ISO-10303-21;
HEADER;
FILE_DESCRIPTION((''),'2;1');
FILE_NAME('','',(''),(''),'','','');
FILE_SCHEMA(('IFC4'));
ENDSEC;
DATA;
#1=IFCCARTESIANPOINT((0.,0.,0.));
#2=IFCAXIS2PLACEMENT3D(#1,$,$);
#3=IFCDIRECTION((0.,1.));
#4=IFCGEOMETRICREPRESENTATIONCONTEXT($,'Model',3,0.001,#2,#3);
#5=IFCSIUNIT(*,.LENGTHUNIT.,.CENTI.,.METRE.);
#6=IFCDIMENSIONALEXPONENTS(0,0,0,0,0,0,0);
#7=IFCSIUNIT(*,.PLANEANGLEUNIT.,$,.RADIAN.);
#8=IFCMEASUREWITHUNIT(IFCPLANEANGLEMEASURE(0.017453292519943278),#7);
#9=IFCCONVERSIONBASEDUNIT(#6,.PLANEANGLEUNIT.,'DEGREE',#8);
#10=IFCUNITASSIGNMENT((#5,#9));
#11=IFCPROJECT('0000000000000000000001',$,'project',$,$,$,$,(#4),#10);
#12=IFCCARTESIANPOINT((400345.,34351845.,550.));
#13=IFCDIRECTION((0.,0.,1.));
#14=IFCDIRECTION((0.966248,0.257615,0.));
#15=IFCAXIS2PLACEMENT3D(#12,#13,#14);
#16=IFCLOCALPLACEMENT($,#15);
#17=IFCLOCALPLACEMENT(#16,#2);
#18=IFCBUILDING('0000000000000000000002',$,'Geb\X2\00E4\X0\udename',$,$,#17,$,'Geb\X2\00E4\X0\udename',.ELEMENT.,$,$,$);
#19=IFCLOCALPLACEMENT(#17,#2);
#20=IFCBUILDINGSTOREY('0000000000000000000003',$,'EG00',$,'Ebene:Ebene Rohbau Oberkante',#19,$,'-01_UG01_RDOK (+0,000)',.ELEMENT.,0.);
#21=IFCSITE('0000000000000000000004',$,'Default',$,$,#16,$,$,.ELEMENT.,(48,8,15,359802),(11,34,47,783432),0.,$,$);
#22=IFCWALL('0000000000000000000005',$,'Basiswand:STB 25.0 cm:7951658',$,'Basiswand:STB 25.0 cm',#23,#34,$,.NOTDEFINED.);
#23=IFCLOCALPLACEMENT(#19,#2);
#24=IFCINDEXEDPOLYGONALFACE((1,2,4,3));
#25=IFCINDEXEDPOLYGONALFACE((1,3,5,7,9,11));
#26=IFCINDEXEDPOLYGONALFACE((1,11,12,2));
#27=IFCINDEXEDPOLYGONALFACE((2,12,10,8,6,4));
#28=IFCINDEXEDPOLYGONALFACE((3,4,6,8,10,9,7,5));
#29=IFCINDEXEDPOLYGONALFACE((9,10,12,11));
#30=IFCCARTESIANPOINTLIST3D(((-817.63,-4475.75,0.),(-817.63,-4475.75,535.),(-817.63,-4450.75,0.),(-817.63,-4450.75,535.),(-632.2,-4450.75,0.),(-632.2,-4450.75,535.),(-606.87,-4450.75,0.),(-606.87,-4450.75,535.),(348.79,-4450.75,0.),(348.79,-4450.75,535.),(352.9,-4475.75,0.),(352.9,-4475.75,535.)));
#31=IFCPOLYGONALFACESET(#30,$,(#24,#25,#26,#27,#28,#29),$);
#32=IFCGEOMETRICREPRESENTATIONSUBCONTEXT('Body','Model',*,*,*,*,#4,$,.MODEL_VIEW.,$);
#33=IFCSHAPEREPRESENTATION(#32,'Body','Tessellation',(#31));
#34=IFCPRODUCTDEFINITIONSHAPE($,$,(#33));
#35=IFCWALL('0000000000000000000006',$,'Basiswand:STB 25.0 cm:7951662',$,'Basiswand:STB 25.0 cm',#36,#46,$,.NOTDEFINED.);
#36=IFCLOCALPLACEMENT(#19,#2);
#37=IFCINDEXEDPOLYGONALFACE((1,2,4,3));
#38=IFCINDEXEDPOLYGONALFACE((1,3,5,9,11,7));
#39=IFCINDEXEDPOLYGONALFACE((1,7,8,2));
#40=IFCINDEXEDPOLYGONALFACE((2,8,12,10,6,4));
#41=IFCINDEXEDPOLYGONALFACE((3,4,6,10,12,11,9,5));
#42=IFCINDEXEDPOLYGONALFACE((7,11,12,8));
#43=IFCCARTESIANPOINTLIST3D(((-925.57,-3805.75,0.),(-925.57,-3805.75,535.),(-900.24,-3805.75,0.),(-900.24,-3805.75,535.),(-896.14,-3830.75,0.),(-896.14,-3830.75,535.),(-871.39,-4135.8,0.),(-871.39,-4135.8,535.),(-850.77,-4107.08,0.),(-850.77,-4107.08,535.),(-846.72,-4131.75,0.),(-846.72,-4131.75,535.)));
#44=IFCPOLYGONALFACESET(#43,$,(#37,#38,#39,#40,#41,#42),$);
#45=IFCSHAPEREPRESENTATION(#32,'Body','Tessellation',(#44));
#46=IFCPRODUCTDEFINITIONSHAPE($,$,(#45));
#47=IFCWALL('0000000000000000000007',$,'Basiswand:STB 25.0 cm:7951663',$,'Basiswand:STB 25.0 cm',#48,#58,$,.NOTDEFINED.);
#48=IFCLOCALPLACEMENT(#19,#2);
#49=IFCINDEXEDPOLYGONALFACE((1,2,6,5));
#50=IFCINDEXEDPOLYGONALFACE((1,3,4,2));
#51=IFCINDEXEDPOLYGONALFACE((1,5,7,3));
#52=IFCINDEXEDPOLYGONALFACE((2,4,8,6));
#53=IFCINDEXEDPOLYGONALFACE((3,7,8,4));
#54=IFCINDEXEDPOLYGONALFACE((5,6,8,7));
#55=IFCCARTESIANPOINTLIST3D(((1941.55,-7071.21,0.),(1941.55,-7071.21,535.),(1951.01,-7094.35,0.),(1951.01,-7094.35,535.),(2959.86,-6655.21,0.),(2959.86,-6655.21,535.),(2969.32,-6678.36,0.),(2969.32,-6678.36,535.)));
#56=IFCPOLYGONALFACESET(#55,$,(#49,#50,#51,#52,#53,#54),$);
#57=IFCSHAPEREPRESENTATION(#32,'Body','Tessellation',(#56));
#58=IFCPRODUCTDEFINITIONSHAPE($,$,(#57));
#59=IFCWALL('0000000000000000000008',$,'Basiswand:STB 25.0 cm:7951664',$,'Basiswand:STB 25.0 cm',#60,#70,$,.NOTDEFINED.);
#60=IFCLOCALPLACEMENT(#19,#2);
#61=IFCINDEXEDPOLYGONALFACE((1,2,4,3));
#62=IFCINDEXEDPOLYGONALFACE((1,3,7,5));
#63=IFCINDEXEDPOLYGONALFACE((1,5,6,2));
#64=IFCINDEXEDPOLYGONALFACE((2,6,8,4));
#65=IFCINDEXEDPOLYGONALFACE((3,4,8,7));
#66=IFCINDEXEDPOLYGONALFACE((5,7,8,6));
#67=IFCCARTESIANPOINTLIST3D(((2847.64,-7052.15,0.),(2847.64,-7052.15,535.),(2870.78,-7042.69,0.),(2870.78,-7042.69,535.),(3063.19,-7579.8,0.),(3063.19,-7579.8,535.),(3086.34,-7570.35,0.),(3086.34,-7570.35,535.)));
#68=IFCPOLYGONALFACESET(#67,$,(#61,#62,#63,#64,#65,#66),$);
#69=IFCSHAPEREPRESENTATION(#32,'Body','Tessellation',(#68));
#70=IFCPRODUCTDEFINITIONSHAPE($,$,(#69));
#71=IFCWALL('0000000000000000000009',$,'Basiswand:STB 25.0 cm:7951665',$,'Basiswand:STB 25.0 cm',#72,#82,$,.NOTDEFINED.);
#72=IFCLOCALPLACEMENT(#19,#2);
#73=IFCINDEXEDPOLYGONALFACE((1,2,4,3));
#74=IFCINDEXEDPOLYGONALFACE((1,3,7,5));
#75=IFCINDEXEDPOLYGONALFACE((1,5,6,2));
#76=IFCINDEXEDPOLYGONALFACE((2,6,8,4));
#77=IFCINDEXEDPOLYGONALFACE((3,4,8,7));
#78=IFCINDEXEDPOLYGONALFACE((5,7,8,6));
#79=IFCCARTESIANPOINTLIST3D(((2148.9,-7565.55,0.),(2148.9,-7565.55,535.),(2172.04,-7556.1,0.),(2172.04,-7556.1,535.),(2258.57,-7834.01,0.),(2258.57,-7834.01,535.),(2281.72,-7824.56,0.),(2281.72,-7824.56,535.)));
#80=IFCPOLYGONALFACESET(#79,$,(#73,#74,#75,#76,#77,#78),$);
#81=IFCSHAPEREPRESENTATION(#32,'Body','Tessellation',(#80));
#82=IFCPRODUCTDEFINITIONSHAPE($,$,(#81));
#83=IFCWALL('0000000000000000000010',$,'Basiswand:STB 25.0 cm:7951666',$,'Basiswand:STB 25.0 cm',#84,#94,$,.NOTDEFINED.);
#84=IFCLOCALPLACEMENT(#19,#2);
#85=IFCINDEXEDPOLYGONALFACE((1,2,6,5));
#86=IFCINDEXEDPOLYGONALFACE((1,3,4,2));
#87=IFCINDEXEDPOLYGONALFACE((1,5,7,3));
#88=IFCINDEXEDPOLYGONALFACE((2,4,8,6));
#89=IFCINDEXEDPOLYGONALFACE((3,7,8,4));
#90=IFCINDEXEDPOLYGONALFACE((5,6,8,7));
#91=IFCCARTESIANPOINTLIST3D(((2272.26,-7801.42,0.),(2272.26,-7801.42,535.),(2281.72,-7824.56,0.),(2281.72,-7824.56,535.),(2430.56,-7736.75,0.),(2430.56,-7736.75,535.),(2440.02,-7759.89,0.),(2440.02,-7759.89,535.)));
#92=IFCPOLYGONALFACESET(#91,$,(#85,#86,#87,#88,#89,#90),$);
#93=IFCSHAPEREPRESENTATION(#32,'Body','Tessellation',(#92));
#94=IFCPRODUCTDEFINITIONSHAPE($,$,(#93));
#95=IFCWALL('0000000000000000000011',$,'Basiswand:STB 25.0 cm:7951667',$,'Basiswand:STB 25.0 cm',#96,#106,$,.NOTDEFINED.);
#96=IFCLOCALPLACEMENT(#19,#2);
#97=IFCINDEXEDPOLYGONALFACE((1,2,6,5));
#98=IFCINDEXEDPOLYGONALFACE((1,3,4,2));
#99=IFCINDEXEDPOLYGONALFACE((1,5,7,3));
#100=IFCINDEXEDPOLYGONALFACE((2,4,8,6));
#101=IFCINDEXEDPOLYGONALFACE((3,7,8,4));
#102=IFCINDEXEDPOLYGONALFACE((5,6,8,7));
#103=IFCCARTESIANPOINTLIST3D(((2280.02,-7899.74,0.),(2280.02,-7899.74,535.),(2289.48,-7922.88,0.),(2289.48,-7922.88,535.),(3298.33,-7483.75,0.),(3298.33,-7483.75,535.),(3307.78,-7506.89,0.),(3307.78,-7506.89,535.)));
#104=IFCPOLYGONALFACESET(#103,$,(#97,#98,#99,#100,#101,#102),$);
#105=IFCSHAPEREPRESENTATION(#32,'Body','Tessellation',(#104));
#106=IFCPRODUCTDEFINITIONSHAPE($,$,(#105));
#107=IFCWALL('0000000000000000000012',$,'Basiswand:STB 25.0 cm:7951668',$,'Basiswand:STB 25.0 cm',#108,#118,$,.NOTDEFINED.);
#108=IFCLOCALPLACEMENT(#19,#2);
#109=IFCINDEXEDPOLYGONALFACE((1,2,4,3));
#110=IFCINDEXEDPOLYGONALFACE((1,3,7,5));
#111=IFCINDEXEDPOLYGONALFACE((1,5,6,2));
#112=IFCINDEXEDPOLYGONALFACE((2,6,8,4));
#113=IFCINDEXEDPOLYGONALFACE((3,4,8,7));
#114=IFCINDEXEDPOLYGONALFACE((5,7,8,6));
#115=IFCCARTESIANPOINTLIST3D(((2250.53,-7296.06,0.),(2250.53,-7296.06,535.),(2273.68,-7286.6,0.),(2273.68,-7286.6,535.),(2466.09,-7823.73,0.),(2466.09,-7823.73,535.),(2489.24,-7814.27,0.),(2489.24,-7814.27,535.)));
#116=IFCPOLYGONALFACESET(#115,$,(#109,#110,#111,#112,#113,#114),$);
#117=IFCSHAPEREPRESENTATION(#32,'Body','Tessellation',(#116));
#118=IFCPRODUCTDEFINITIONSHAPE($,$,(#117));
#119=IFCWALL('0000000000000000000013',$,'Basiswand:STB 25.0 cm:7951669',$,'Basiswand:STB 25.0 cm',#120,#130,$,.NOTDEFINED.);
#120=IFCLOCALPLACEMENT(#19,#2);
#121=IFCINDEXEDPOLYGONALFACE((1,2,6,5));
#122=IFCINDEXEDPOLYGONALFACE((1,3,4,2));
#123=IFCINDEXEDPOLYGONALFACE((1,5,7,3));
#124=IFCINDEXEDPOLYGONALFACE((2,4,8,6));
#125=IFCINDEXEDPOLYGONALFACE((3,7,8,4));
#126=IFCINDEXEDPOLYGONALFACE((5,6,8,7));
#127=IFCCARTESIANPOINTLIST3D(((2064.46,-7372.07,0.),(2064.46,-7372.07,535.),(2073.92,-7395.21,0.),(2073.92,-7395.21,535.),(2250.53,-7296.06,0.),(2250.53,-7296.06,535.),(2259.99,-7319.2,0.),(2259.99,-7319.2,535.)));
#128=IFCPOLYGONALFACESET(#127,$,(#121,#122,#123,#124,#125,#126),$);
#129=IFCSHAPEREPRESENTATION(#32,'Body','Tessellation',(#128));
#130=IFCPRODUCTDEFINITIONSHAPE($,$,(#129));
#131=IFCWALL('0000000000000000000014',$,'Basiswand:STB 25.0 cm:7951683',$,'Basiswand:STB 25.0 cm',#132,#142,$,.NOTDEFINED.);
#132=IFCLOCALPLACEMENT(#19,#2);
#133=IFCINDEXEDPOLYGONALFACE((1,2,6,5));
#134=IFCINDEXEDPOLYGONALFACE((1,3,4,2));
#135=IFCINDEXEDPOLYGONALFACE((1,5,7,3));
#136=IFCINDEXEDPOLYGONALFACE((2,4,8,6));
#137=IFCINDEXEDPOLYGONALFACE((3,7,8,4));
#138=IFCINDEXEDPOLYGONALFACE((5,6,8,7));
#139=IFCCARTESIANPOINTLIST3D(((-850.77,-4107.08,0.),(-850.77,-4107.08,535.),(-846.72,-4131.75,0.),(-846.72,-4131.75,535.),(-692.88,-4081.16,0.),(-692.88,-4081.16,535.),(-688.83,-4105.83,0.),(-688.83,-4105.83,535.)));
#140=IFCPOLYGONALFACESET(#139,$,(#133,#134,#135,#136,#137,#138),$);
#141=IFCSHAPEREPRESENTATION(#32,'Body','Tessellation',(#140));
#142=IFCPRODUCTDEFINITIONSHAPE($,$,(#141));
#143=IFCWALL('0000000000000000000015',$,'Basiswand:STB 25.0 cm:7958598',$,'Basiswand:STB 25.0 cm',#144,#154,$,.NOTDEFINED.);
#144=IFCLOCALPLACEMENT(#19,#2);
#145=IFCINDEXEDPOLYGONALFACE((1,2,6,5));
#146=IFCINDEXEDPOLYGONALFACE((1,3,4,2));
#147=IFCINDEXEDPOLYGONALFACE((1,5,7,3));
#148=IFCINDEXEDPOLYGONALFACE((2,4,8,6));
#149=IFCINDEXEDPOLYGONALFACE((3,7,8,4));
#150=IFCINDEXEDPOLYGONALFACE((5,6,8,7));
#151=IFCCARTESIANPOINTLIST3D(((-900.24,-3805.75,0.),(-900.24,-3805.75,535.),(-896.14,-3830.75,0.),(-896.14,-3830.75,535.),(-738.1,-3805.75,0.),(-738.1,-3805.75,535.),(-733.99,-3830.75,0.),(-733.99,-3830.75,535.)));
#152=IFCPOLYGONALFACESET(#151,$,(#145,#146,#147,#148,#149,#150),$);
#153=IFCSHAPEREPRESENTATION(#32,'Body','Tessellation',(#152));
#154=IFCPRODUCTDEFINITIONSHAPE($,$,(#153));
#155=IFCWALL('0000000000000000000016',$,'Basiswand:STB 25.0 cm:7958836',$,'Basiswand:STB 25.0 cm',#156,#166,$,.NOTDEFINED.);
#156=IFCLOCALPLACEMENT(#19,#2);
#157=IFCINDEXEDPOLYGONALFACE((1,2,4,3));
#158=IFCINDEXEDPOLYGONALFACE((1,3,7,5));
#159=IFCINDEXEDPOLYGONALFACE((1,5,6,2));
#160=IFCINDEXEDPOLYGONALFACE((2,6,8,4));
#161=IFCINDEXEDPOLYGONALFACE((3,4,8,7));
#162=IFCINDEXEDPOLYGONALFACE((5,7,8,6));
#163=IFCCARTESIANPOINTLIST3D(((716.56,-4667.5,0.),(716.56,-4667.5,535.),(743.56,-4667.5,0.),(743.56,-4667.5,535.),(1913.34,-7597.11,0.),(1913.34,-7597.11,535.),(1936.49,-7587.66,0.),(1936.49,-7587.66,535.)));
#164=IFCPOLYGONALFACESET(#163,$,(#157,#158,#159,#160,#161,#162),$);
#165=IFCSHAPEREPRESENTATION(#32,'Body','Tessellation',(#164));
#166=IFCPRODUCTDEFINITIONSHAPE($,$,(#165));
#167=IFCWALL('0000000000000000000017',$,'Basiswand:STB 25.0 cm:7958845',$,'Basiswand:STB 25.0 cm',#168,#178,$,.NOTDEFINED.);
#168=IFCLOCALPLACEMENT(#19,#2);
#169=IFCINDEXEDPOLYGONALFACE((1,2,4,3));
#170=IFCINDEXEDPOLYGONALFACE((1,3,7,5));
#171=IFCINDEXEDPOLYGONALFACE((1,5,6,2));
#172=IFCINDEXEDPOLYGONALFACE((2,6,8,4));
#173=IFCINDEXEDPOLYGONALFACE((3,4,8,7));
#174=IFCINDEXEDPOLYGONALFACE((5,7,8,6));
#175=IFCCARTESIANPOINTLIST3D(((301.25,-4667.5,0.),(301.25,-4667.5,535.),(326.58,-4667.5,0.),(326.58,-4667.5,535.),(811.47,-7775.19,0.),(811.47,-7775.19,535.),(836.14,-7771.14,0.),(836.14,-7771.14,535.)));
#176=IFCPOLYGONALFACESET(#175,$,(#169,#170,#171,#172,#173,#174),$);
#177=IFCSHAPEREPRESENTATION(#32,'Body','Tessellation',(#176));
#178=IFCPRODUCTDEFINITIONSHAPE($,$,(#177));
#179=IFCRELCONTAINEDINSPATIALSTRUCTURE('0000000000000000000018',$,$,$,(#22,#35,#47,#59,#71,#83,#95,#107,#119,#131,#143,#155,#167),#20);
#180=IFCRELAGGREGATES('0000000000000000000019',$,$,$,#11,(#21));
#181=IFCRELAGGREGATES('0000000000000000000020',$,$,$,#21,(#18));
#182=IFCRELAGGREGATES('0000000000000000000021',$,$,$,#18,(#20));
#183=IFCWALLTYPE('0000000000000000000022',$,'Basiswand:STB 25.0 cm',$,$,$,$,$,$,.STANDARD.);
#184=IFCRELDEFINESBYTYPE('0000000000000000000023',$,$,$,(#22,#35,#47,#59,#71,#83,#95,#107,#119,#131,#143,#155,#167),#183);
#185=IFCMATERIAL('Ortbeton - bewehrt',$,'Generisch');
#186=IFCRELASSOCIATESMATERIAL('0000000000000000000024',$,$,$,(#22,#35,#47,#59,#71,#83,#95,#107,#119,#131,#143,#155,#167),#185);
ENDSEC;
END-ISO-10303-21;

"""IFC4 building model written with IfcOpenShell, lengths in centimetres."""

from ifc_helpers import new_model, entity, si_unit, converted_unit, direction, frame, origin, place, context, subcontext, project, spatial, indexed_curve, outline, extrude, material, type_object, element, save


model = new_model("IFC4")

# Units and contexts
model_context = context("Model", 3, precision=0.001, world=origin(), true_north=direction((0.0, 1.0)))
body_context = subcontext(model_context, "Body", "Model", "MODEL_VIEW")
ifc_project = project(units=[si_unit("LENGTHUNIT", "METRE", prefix="CENTI"), converted_unit("PLANEANGLEUNIT", "DEGREE", entity("IfcPlaneAngleMeasure", 0.017453292519943278), si_unit("PLANEANGLEUNIT", "RADIAN"), dimensions=[0, 0, 0, 0, 0, 0, 0])], contexts=[model_context])

# Site, building, storey
site_placement = place(None, frame((400345.0, 34351845.0, 550.0), z_axis=(0.0, 0.0, 1.0), x_axis=(0.966248, 0.257615, 0.0)))
site = spatial("IfcSite", under=ifc_project, at=site_placement, Name="Default", CompositionType="ELEMENT", RefLatitude=(48, 8, 15, 359802), RefLongitude=(11, 34, 47, 783432), RefElevation=0.0)
building_placement = place(site_placement, origin())
building = spatial("IfcBuilding", under=site, at=building_placement, Name="Gebäudename", LongName="Gebäudename", CompositionType="ELEMENT")
storey_placement = place(building_placement, origin())
storey = spatial("IfcBuildingStorey", under=building, at=storey_placement, Name="EG00", ObjectType="Ebene:Ebene Rohbau Oberkante", LongName="-01_UG01_RDOK (+0,000)", CompositionType="ELEMENT", Elevation=0.0)

# Walls
ifc_material = material(Name="Ortbeton - bewehrt", Category="Generisch")
wall_type_1 = type_object("IfcWallType", Name="Basiswand:STB 25.0 cm", PredefinedType="STANDARD")
wall_1_placement = place(storey_placement, frame((352.9, -4463.25, 0.0), z_axis=(0.0, 0.0, 1.0), x_axis=(-1.0, 0.0, 0.0)))
element("IfcWall", 1, at=wall_1_placement, inside=storey, type_object=wall_type_1, material=ifc_material, Name="Basiswand:STB 25.0 cm:7951658", ObjectType="Basiswand:STB 25.0 cm", PredefinedType="NOTDEFINED", context=body_context, shape_type="SweptSolid", body=[
    extrude(outline(indexed_curve([(1170.53, -12.5), (1170.53, 12.5), (0.0, 12.5), (4.1, -12.5), (959.77, -12.5), (985.1, -12.5), (1170.53, -12.5)], self_intersect=False)), origin(), (0.0, 0.0, 1.0), 535.0),
])
wall_2_placement = place(storey_placement, frame((-859.05, -4133.78, 0.0), z_axis=(0.0, 0.0, 1.0), x_axis=(-0.162011, 0.986789, 0.0)))
element("IfcWall", 2, at=wall_2_placement, inside=storey, type_object=wall_type_1, material=ifc_material, Name="Basiswand:STB 25.0 cm:7951662", ObjectType="Basiswand:STB 25.0 cm", PredefinedType="NOTDEFINED", context=body_context, shape_type="SweptSolid", body=[
    extrude(outline(indexed_curve([(330.37, -12.5), (334.48, 12.5), (0.0, 12.5), (0.0, -12.5), (25.0, -12.5), (305.04, -12.5), (330.37, -12.5)], self_intersect=False)), origin(), (0.0, 0.0, 1.0), 535.0),
])
wall_3_placement = place(storey_placement, frame((1946.28, -7082.78, 0.0), z_axis=(0.0, 0.0, 1.0), x_axis=(0.925734, 0.378175, 0.0)))
element("IfcWall", 3, at=wall_3_placement, inside=storey, type_object=wall_type_1, material=ifc_material, Name="Basiswand:STB 25.0 cm:7951663", ObjectType="Basiswand:STB 25.0 cm", PredefinedType="NOTDEFINED", context=body_context, shape_type="SweptSolid", body=[
    extrude(outline(indexed_curve([(1100.0, 12.5), (0.0, 12.5), (0.0, -12.5), (1100.0, -12.5), (1100.0, 12.5)], self_intersect=False)), origin(), (0.0, 0.0, 1.0), 535.0),
])
wall_4_placement = place(storey_placement, frame((2859.21, -7047.42, 0.0), z_axis=(0.0, 0.0, 1.0), x_axis=(0.378175, -0.925734, 0.0)))
element("IfcWall", 4, at=wall_4_placement, inside=storey, type_object=wall_type_1, material=ifc_material, Name="Basiswand:STB 25.0 cm:7951664", ObjectType="Basiswand:STB 25.0 cm", PredefinedType="NOTDEFINED", context=body_context, shape_type="SweptSolid", body=[
    extrude(outline(indexed_curve([(569.99, 12.5), (0.0, 12.5), (0.0, -12.5), (569.99, -12.5), (569.99, 12.5)], self_intersect=False)), origin(), (0.0, 0.0, 1.0), 535.0),
])
wall_5_placement = place(storey_placement, frame((2160.47, -7560.82, 0.0), z_axis=(0.0, 0.0, 1.0), x_axis=(0.378175, -0.925734, 0.0)))
element("IfcWall", 5, at=wall_5_placement, inside=storey, type_object=wall_type_1, material=ifc_material, Name="Basiswand:STB 25.0 cm:7951665", ObjectType="Basiswand:STB 25.0 cm", PredefinedType="NOTDEFINED", context=body_context, shape_type="SweptSolid", body=[
    extrude(outline(indexed_curve([(290.0, 12.5), (0.0, 12.5), (0.0, -12.5), (290.0, -12.5), (290.0, 12.5)], self_intersect=False)), origin(), (0.0, 0.0, 1.0), 535.0),
])
wall_6_placement = place(storey_placement, frame((2276.99, -7812.99, 0.0), z_axis=(0.0, 0.0, 1.0), x_axis=(0.925734, 0.378175, 0.0)))
element("IfcWall", 6, at=wall_6_placement, inside=storey, type_object=wall_type_1, material=ifc_material, Name="Basiswand:STB 25.0 cm:7951666", ObjectType="Basiswand:STB 25.0 cm", PredefinedType="NOTDEFINED", context=body_context, shape_type="SweptSolid", body=[
    extrude(outline(indexed_curve([(171.0, 12.5), (0.0, 12.5), (0.0, -12.5), (171.0, -12.5), (171.0, 12.5)], self_intersect=False)), origin(), (0.0, 0.0, 1.0), 535.0),
])
wall_7_placement = place(storey_placement, frame((3303.06, -7495.32, 0.0), z_axis=(0.0, 0.0, 1.0), x_axis=(-0.925734, -0.378175, 0.0)))
element("IfcWall", 7, at=wall_7_placement, inside=storey, type_object=wall_type_1, material=ifc_material, Name="Basiswand:STB 25.0 cm:7951667", ObjectType="Basiswand:STB 25.0 cm", PredefinedType="NOTDEFINED", context=body_context, shape_type="SweptSolid", body=[
    extrude(outline(indexed_curve([(1100.0, 12.5), (0.0, 12.5), (0.0, -12.5), (1100.0, -12.5), (1100.0, 12.5)], self_intersect=False)), origin(), (0.0, 0.0, 1.0), 535.0),
])
wall_8_placement = place(storey_placement, frame((2262.11, -7291.33, 0.0), z_axis=(0.0, 0.0, 1.0), x_axis=(0.378175, -0.925734, 0.0)))
element("IfcWall", 8, at=wall_8_placement, inside=storey, type_object=wall_type_1, material=ifc_material, Name="Basiswand:STB 25.0 cm:7951668", ObjectType="Basiswand:STB 25.0 cm", PredefinedType="NOTDEFINED", context=body_context, shape_type="SweptSolid", body=[
    extrude(outline(indexed_curve([(570.0, 12.5), (0.0, 12.5), (0.0, -12.5), (570.0, -12.5), (570.0, 12.5)], self_intersect=False)), origin(), (0.0, 0.0, 1.0), 535.0),
])
wall_9_placement = place(storey_placement, frame((2069.19, -7383.64, 0.0), z_axis=(0.0, 0.0, 1.0), x_axis=(0.925734, 0.378175, 0.0)))
element("IfcWall", 9, at=wall_9_placement, inside=storey, type_object=wall_type_1, material=ifc_material, Name="Basiswand:STB 25.0 cm:7951669", ObjectType="Basiswand:STB 25.0 cm", PredefinedType="NOTDEFINED", context=body_context, shape_type="SweptSolid", body=[
    extrude(outline(indexed_curve([(201.0, 12.5), (0.0, 12.5), (0.0, -12.5), (201.0, -12.5), (201.0, 12.5)], self_intersect=False)), origin(), (0.0, 0.0, 1.0), 535.0),
])
wall_10_placement = place(storey_placement, frame((-848.74, -4119.42, 0.0), z_axis=(0.0, 0.0, 1.0), x_axis=(0.986789, 0.162011, 0.0)))
element("IfcWall", 10, at=wall_10_placement, inside=storey, type_object=wall_type_1, material=ifc_material, Name="Basiswand:STB 25.0 cm:7951683", ObjectType="Basiswand:STB 25.0 cm", PredefinedType="NOTDEFINED", context=body_context, shape_type="SweptSolid", body=[
    extrude(outline(indexed_curve([(160.0, 12.5), (0.0, 12.5), (0.0, -12.5), (160.0, -12.5), (160.0, 12.5)], self_intersect=False)), origin(), (0.0, 0.0, 1.0), 535.0),
])
wall_11_placement = place(storey_placement, frame((-900.24, -3818.25, 0.0)))
element("IfcWall", 11, at=wall_11_placement, inside=storey, type_object=wall_type_1, material=ifc_material, Name="Basiswand:STB 25.0 cm:7958598", ObjectType="Basiswand:STB 25.0 cm", PredefinedType="NOTDEFINED", context=body_context, shape_type="SweptSolid", body=[
    extrude(outline(indexed_curve([(166.25, -12.5), (162.14, 12.5), (0.0, 12.5), (4.1, -12.5), (166.25, -12.5)], self_intersect=False)), origin(), (0.0, 0.0, 1.0), 535.0),
])
wall_12_placement = place(storey_placement, frame((728.13, -4662.77, 0.0), z_axis=(0.0, 0.0, 1.0), x_axis=(0.378175, -0.925734, 0.0)))
element("IfcWall", 12, at=wall_12_placement, inside=storey, type_object=wall_type_1, material=ifc_material, Name="Basiswand:STB 25.0 cm:7958836", ObjectType="Basiswand:STB 25.0 cm", PredefinedType="NOTDEFINED", context=body_context, shape_type="SweptSolid", body=[
    extrude(outline(indexed_curve([(3164.64, -12.5), (3164.64, 12.5), (10.21, 12.5), (0.0, -12.5), (3164.64, -12.5)], self_intersect=False)), origin(), (0.0, 0.0, 1.0), 535.0),
])
wall_13_placement = place(storey_placement, frame((313.58, -4665.47, 0.0), z_axis=(0.0, 0.0, 1.0), x_axis=(0.162011, -0.986789, 0.0)))
element("IfcWall", 13, at=wall_13_placement, inside=storey, type_object=wall_type_1, material=ifc_material, Name="Basiswand:STB 25.0 cm:7958845", ObjectType="Basiswand:STB 25.0 cm", PredefinedType="NOTDEFINED", context=body_context, shape_type="SweptSolid", body=[
    extrude(outline(indexed_curve([(3149.3, -12.5), (3149.3, 12.5), (4.1, 12.5), (0.0, -12.5), (3149.3, -12.5)], self_intersect=False)), origin(), (0.0, 0.0, 1.0), 535.0),
])

save(model, "model.ifc")
